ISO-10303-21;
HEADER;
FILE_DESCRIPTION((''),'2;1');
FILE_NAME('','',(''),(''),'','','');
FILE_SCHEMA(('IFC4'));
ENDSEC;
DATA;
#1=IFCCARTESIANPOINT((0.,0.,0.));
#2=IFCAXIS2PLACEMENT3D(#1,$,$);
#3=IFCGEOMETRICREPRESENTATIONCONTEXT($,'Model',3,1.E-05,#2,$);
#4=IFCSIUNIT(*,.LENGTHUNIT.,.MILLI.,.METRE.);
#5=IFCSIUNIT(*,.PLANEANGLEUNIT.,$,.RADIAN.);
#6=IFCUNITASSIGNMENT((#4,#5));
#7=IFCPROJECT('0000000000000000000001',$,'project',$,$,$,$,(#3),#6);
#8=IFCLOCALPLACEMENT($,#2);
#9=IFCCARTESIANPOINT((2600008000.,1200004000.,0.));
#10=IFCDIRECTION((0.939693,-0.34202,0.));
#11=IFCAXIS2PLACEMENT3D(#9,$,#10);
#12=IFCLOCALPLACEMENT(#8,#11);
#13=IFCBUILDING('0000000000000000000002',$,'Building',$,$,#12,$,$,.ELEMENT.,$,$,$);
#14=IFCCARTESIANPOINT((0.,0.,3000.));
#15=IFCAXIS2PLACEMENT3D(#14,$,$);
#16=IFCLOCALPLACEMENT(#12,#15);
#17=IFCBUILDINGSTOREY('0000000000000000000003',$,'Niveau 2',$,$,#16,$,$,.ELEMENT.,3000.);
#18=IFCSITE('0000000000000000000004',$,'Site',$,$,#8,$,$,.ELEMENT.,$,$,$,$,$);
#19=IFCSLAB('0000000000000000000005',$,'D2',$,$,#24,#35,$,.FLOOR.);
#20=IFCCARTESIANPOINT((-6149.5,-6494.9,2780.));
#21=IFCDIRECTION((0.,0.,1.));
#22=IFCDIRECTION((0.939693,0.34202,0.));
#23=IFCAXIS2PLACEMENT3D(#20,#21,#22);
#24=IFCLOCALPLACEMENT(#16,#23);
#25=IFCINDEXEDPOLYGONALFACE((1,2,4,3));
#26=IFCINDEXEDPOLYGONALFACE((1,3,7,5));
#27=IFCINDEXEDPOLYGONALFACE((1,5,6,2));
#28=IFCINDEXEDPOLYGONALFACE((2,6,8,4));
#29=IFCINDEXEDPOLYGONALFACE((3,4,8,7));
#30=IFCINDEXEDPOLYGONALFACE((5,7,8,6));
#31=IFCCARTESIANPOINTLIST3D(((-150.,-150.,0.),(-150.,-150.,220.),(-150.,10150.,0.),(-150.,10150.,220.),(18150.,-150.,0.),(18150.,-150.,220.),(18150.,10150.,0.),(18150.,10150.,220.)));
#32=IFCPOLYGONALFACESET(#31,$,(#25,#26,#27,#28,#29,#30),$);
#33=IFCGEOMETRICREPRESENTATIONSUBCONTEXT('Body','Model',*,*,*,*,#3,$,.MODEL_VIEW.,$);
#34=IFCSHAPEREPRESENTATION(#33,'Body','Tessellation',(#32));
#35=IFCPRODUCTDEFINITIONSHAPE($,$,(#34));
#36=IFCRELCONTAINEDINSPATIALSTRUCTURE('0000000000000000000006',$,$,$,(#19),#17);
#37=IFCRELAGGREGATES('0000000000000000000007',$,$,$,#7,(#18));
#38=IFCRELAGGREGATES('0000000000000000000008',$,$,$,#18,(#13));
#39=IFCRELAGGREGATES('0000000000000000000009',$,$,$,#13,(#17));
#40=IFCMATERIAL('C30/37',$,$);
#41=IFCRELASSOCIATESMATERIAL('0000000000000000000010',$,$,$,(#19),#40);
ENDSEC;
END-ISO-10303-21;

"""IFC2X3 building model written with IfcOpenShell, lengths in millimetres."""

from ifc_helpers import new_model, si_unit, frame, origin, place, context, subcontext, project, spatial, polyline, outline, extrude, material, element, save


model = new_model("IFC2X3")

# Units and contexts
model_context = context("Model", 3, precision=1e-05, world=origin())
body_context = subcontext(model_context, "Body", "Model", "MODEL_VIEW")
ifc_project = project(units=[si_unit("LENGTHUNIT", "METRE", prefix="MILLI"), si_unit("PLANEANGLEUNIT", "RADIAN")], contexts=[model_context])

# Site, building, storey
site_placement = place(None, origin())
site = spatial("IfcSite", under=ifc_project, at=site_placement, Name="Site", CompositionType="ELEMENT")
building_placement = place(site_placement, frame((2600008000.0, 1200004000.0, 0.0), x_axis=(0.939693, -0.34202, 0.0)))
building = spatial("IfcBuilding", under=site, at=building_placement, Name="Building", CompositionType="ELEMENT")
storey_placement = place(building_placement, frame((0.0, 0.0, 3000.0)))
storey = spatial("IfcBuildingStorey", under=building, at=storey_placement, Name="Niveau 2", CompositionType="ELEMENT", Elevation=3000.0)

# Shared definitions
ifc_material = material(Name="C30/37")

# Slab
slab_placement = place(storey_placement, frame((-6149.5, -6494.9, 2780.0), z_axis=(0.0, 0.0, 1.0), x_axis=(0.939693, 0.34202, 0.0)))
element("IfcSlab", 1, at=slab_placement, inside=storey, material=ifc_material, Name="D2", PredefinedType="FLOOR", context=body_context, shape_type="SweptSolid", body=[
    extrude(outline(polyline([(-150.0, -150.0), (18150.0, -150.0), (18150.0, 10150.0), (-150.0, 10150.0), (-150.0, -150.0)])), origin(), (0.0, 0.0, 1.0), 220.0),
])

save(model, "model.ifc")
